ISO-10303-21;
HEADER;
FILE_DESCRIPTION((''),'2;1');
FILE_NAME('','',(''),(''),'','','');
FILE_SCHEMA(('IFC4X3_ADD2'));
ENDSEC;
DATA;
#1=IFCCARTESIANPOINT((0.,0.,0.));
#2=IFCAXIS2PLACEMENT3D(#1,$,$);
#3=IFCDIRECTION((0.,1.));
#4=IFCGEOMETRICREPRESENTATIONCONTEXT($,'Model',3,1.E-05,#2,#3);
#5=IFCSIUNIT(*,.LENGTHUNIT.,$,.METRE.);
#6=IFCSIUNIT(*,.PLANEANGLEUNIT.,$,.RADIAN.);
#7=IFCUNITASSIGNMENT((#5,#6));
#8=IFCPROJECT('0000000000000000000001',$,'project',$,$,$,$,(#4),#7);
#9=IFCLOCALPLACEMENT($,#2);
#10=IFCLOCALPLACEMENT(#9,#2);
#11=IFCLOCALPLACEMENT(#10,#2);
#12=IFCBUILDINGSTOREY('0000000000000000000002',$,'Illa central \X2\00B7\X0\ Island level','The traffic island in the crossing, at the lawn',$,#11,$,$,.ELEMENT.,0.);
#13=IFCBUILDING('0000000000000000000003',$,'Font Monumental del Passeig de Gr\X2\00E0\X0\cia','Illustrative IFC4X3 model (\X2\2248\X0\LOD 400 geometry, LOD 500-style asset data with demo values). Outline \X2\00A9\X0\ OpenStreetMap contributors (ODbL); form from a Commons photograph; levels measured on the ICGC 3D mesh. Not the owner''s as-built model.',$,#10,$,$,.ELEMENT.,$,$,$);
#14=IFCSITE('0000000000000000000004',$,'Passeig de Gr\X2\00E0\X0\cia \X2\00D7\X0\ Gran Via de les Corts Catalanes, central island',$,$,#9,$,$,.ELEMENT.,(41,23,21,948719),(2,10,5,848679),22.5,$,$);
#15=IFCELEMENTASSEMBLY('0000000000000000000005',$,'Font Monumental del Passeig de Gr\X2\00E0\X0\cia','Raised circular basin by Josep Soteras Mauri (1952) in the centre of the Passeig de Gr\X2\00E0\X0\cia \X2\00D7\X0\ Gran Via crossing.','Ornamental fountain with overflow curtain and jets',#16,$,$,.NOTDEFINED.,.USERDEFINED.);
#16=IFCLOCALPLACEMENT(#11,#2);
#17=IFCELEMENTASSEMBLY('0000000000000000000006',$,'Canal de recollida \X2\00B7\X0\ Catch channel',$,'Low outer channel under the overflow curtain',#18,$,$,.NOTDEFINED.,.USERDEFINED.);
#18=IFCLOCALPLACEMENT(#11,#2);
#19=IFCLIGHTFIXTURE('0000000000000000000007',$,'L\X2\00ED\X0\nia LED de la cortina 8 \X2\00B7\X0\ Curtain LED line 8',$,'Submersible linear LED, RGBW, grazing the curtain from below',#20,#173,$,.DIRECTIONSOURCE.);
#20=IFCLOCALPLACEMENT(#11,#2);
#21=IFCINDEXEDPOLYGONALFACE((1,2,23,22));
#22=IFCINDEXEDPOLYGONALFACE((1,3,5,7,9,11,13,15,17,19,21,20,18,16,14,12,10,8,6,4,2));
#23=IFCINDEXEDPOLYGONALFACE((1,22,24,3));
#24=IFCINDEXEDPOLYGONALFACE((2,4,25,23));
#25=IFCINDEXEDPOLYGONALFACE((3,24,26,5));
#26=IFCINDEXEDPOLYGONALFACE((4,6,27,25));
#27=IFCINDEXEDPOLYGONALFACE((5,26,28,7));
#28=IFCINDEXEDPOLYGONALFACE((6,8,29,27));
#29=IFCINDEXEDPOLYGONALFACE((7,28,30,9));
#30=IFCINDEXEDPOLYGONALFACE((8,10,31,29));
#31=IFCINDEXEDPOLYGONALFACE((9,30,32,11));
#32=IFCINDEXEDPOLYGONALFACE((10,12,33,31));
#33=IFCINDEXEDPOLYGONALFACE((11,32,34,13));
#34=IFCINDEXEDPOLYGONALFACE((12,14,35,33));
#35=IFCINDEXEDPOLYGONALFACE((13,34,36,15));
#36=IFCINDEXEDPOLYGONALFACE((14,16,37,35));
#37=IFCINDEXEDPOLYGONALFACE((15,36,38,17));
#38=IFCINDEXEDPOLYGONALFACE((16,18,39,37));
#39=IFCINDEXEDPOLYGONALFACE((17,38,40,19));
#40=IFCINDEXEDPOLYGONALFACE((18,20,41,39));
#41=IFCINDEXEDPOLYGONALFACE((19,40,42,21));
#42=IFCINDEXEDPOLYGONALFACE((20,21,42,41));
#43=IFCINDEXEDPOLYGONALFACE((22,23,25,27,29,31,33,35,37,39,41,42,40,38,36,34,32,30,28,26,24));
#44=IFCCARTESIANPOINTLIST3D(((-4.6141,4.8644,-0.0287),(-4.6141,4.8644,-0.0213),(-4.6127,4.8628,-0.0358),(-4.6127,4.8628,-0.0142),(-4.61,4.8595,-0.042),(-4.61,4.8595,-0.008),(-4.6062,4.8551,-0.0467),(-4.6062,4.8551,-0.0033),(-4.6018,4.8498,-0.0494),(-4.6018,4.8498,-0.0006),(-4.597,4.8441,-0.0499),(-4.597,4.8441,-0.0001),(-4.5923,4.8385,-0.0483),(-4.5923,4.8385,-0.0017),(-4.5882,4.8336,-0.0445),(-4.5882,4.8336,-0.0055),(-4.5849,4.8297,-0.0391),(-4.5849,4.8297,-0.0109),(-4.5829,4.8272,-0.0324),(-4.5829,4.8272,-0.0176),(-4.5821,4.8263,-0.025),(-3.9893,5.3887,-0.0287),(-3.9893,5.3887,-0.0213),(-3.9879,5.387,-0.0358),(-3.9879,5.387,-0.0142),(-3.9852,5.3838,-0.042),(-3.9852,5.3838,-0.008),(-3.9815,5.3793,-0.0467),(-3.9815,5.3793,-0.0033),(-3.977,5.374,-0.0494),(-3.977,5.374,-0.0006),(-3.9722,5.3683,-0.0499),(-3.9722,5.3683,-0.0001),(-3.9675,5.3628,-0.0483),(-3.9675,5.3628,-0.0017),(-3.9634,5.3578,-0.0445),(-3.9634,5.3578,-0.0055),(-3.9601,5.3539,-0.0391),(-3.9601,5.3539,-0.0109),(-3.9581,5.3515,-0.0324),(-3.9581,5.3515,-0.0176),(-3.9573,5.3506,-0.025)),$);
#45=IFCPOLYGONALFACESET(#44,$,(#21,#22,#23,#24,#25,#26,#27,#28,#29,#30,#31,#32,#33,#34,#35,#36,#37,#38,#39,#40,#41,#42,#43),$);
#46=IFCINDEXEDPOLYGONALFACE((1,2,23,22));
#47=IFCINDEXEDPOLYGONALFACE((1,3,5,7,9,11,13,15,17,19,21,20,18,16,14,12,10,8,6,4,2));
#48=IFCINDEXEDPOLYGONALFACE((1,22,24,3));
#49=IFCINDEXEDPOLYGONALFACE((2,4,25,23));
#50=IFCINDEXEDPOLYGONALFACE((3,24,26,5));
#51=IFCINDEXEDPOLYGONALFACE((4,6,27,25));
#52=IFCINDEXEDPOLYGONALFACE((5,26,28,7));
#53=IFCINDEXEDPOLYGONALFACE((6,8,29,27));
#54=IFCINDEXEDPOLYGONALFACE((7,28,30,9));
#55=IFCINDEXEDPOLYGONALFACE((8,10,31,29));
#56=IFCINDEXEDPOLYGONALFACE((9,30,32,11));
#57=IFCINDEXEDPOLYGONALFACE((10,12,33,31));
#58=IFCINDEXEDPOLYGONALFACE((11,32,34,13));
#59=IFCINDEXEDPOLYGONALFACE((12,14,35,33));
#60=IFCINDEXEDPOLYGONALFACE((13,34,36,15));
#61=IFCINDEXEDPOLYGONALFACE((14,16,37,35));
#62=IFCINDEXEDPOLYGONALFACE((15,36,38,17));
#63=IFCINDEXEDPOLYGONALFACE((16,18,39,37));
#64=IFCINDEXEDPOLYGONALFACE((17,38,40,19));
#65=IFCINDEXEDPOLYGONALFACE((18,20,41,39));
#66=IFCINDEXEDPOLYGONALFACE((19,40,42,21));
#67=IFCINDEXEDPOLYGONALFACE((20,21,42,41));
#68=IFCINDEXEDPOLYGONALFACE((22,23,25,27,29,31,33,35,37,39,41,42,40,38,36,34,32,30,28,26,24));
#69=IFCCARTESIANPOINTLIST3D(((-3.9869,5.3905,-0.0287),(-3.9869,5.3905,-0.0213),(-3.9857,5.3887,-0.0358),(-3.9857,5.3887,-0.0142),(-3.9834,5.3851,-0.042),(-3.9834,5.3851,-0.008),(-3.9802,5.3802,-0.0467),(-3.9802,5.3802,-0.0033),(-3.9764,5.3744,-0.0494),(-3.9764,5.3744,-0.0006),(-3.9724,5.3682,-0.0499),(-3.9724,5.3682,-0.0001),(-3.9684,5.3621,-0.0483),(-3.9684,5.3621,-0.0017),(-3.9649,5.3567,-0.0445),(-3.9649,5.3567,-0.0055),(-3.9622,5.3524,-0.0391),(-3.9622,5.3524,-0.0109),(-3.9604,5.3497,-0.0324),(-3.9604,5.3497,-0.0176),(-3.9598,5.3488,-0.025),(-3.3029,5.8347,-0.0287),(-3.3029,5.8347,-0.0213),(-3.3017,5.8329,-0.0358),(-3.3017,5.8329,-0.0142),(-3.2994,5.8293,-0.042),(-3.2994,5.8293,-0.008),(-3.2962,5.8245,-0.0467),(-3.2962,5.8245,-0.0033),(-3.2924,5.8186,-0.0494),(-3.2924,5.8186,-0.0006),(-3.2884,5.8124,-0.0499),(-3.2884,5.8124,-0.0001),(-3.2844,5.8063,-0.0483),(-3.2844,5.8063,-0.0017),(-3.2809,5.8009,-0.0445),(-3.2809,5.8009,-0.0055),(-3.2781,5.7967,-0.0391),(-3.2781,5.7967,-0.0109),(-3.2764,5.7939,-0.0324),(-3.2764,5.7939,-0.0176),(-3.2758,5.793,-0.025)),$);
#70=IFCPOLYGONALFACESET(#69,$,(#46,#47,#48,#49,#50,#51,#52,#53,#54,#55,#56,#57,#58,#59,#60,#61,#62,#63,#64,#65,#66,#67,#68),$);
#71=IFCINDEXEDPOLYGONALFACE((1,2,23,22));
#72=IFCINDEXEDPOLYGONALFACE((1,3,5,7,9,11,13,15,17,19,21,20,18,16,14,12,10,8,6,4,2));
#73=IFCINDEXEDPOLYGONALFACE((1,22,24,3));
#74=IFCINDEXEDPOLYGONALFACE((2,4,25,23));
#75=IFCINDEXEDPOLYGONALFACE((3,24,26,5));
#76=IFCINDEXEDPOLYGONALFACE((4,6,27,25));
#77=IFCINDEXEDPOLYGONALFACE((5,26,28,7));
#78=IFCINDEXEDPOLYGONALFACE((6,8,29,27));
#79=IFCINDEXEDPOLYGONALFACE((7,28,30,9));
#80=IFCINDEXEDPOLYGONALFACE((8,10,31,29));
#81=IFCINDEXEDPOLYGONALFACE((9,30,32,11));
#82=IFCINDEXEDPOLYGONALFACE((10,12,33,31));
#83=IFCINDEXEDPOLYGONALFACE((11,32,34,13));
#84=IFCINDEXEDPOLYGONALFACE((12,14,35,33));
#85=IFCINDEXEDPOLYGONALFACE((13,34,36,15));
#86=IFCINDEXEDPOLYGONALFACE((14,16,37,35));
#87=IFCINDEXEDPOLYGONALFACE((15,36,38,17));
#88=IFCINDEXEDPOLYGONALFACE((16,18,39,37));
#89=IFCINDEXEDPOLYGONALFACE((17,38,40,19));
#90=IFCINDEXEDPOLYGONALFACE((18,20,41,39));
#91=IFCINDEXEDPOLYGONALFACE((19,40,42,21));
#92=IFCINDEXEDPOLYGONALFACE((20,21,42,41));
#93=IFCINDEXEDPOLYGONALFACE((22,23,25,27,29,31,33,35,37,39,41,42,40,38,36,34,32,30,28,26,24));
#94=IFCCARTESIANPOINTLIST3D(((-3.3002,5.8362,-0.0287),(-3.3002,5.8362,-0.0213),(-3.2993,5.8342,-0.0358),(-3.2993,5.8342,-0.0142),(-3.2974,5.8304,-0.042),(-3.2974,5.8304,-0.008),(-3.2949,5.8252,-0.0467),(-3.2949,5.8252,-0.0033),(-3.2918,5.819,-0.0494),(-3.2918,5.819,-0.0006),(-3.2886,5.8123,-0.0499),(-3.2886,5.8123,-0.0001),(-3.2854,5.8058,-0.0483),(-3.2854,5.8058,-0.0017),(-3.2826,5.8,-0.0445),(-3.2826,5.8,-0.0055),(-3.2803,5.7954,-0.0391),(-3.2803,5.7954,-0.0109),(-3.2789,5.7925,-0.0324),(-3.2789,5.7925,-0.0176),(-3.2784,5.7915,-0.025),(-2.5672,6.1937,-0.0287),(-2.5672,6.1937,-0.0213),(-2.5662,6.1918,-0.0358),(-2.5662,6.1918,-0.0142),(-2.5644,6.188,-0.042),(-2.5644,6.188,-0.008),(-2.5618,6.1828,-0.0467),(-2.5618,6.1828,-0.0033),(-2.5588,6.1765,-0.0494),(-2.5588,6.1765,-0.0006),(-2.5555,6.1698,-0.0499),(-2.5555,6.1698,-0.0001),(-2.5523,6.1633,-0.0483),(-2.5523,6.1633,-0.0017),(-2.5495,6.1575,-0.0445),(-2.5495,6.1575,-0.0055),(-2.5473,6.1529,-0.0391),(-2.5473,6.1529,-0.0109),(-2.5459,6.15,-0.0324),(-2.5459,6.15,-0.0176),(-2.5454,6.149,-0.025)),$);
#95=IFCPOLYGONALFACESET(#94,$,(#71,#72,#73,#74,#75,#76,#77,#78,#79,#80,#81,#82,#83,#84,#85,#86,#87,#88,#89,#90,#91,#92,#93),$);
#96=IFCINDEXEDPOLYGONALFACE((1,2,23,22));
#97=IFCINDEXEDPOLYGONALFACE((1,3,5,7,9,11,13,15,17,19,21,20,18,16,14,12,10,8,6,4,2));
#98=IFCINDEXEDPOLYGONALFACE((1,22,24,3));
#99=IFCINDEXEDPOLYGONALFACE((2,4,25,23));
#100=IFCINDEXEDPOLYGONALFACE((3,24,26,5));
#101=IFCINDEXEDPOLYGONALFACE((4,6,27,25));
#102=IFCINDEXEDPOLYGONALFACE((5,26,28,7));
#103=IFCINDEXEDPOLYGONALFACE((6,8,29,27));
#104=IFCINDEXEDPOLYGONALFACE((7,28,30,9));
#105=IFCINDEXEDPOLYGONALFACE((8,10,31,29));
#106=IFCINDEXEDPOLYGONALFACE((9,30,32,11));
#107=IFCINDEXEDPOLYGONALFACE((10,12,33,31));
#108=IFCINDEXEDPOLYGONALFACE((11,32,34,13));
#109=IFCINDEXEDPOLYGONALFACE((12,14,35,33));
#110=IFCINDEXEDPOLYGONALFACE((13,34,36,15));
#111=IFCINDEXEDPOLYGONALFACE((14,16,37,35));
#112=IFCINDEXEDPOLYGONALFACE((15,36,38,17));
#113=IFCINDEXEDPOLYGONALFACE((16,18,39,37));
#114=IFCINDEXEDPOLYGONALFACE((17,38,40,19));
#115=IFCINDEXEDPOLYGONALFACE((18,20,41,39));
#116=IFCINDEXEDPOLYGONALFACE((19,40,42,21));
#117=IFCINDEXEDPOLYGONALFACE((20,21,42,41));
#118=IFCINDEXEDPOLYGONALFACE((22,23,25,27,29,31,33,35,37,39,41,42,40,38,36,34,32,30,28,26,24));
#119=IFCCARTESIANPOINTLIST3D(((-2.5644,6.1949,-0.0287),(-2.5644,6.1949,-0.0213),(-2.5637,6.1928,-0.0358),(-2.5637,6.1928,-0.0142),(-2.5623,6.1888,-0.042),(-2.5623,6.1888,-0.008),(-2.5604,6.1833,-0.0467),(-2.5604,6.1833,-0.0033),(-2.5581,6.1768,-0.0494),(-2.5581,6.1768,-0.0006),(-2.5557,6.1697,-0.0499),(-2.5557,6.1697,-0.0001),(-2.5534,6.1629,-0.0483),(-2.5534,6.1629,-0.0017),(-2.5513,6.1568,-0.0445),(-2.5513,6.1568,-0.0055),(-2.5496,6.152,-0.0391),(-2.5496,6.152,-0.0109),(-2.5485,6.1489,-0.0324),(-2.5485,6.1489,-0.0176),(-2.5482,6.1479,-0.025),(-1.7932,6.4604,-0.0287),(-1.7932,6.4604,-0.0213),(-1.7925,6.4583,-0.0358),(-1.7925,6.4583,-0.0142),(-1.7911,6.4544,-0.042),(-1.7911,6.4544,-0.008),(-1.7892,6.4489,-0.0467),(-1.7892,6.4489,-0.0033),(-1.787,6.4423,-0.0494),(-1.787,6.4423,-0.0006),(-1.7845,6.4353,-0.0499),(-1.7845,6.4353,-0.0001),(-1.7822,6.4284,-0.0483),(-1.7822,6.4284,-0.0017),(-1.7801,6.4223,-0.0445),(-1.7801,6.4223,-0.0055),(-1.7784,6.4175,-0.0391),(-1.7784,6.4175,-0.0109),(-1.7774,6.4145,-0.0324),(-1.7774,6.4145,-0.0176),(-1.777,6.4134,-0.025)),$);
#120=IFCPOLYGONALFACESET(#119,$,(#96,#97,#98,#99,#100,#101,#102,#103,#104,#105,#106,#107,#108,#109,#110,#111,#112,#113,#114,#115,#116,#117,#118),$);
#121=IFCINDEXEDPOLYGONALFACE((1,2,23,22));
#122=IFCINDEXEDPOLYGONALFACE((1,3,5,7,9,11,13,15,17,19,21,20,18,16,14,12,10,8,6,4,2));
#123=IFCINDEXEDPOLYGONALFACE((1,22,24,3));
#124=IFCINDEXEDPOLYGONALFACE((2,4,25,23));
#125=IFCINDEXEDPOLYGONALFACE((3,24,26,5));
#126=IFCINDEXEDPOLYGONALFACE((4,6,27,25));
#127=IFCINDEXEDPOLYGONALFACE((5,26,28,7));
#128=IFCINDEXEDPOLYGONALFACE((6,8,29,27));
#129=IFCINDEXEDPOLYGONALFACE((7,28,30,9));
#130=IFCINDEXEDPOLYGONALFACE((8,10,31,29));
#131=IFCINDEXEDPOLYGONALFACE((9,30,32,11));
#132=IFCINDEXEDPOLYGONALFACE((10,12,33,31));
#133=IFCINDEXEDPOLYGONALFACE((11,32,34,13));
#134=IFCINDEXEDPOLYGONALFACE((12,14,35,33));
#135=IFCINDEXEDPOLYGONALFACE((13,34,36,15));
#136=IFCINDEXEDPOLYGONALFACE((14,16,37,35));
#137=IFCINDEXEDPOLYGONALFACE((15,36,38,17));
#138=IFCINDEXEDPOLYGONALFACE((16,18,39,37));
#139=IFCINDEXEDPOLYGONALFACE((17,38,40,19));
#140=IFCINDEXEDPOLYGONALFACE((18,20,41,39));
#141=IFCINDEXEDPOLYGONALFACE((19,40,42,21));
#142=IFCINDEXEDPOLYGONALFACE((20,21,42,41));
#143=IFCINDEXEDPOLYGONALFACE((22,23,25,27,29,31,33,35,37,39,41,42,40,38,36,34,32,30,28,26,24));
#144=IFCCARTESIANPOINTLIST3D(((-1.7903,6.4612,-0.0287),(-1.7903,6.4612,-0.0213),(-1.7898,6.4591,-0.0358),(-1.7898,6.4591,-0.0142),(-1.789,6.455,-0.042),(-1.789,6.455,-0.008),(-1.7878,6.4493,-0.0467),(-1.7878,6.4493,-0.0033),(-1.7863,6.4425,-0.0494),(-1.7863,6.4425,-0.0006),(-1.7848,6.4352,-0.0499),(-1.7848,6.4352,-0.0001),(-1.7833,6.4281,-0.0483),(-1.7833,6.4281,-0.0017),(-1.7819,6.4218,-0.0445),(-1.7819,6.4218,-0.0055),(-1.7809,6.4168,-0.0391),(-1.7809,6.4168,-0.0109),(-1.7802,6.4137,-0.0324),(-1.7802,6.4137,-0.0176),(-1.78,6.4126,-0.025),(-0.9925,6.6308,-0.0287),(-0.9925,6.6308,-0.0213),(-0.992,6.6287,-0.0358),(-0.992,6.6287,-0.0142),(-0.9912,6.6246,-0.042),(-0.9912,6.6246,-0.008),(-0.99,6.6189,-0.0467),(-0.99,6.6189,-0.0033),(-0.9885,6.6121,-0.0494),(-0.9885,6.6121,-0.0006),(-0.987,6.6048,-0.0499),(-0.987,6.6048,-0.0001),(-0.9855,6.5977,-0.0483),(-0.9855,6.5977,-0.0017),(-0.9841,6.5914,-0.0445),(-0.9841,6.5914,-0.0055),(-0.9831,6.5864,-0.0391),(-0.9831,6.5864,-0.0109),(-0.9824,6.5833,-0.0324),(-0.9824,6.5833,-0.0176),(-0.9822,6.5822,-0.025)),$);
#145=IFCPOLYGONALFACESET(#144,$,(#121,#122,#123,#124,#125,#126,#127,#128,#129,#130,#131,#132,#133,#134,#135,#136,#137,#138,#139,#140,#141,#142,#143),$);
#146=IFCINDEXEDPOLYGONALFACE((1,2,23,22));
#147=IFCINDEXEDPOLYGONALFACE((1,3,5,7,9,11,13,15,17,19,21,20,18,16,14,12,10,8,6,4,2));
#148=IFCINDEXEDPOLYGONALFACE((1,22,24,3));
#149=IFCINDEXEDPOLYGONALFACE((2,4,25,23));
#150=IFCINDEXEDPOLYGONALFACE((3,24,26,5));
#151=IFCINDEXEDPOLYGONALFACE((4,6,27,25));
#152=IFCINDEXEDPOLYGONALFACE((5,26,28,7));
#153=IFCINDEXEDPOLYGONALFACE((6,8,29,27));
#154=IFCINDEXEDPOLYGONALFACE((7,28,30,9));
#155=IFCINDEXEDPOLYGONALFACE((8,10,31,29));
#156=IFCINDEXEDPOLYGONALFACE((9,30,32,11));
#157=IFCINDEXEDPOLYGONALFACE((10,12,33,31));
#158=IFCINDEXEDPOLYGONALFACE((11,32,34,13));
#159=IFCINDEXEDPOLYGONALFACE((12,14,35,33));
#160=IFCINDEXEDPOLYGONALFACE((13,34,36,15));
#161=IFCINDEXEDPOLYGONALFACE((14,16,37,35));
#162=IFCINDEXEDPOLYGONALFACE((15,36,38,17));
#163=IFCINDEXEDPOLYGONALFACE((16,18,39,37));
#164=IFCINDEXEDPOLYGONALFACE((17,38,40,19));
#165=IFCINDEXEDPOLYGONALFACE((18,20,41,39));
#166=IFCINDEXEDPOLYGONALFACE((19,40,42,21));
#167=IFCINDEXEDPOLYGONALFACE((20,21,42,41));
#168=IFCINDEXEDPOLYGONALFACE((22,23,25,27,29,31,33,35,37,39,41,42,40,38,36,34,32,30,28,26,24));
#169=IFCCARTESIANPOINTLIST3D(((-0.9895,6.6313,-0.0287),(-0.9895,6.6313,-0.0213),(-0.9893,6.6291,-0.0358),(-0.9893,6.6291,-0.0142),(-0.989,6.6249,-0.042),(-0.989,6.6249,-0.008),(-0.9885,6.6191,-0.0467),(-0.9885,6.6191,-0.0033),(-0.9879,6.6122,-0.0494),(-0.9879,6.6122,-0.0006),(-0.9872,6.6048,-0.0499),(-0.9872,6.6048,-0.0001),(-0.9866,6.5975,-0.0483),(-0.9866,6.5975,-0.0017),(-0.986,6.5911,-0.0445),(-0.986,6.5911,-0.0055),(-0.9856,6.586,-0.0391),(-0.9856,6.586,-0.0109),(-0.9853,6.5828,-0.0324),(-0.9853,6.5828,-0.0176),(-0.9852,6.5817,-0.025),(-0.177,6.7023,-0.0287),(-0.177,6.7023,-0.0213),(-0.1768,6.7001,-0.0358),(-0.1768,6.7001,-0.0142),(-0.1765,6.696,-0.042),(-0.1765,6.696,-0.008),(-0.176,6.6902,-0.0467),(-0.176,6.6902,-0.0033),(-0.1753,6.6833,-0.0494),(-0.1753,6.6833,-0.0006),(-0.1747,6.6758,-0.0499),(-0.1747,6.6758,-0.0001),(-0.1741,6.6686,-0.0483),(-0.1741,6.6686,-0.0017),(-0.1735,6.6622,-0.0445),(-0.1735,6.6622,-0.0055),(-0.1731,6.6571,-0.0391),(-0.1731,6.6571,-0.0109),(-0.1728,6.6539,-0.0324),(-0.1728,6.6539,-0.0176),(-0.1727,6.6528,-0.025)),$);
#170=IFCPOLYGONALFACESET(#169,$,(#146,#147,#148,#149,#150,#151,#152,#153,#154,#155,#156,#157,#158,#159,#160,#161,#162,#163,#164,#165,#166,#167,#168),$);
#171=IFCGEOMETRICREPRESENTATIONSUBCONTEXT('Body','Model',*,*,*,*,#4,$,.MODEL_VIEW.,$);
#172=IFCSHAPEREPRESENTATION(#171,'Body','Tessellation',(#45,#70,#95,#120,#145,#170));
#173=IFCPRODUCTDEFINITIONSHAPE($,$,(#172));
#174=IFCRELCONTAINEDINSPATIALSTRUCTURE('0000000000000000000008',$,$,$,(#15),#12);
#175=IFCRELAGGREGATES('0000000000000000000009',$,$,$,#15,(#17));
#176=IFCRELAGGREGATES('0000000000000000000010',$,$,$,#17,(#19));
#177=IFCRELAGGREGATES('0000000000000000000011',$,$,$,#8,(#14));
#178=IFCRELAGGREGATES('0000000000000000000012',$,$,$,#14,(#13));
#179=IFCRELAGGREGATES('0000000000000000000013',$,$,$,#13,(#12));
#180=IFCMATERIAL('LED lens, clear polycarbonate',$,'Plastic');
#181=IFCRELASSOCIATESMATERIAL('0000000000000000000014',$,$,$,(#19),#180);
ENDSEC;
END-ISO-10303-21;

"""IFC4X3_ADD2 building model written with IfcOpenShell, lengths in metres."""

from ifc_helpers import new_model, si_unit, direction, frame, origin, origin_2d_with_axis, place, context, subcontext, project, spatial, circle, extrude, material, element, aggregate, save


model = new_model("IFC4X3_ADD2")

# Units and contexts
model_context = context("Model", 3, precision=1e-05, world=origin(), true_north=direction((0.0, 1.0)))
body_context = subcontext(model_context, "Body", "Model", "MODEL_VIEW")
ifc_project = project(units=[si_unit("LENGTHUNIT", "METRE"), si_unit("PLANEANGLEUNIT", "RADIAN")], contexts=[model_context])

# Site, building, storey
site_placement = place(None, origin())
site = spatial("IfcSite", under=ifc_project, at=site_placement, Name="Passeig de Gràcia × Gran Via de les Corts Catalanes, central island", CompositionType="ELEMENT", RefLatitude=(41, 23, 21, 948719), RefLongitude=(2, 10, 5, 848679), RefElevation=22.5)
building_placement = place(site_placement, origin())
building = spatial("IfcBuilding", under=site, at=building_placement, Name="Font Monumental del Passeig de Gràcia", Description="Illustrative IFC4X3 model (≈LOD 400 geometry, LOD 500-style asset data with demo values). Outline © OpenStreetMap contributors (ODbL); form from a Commons photograph; levels measured on the ICGC 3D mesh. Not the owner's as-built model.", CompositionType="ELEMENT")
storey_placement = place(building_placement, origin())
storey = spatial("IfcBuildingStorey", under=building, at=storey_placement, Name="Illa central · Island level", Description="The traffic island in the crossing, at the lawn", CompositionType="ELEMENT", Elevation=0.0)

# Element assemblies, light fixture
assembly_1_placement = place(building_placement, origin())
assembly_1 = element("IfcElementAssembly", 1, at=assembly_1_placement, inside=storey, Name="Font Monumental del Passeig de Gràcia", Description="Raised circular basin by Josep Soteras Mauri (1952) in the centre of the Passeig de Gràcia × Gran Via crossing.", ObjectType="Ornamental fountain with overflow curtain and jets", AssemblyPlace="NOTDEFINED", PredefinedType="USERDEFINED")
assembly_2_placement = place(building_placement, origin())
assembly_2 = element("IfcElementAssembly", 2, at=assembly_2_placement, Name="Canal de recollida · Catch channel", ObjectType="Low outer channel under the overflow curtain", AssemblyPlace="NOTDEFINED", PredefinedType="USERDEFINED")
ifc_material_1 = material(Name="LED lens, clear polycarbonate", Category="Plastic")
light_fixture_1_placement = place(building_placement, origin())
light_fixture_1 = element("IfcLightFixture", 3, at=light_fixture_1_placement, material=ifc_material_1, Name="Línia LED de la cortina 8 · Curtain LED line 8", ObjectType="Submersible linear LED, RGBW, grazing the curtain from below", PredefinedType="DIRECTIONSOURCE", context=body_context, shape_type="SweptSolid", body=[
    extrude(circle(Radius=0.025, at=origin_2d_with_axis()), frame((-4.5982, 4.8455, -0.025), z_axis=(0.766044, 0.642788, 0.0), x_axis=(0.642788, -0.766044, 0.0)), (0.0, 0.0, 1.0), 0.8156),
    extrude(circle(Radius=0.025, at=origin_2d_with_axis()), frame((-3.9734, 5.3698, -0.025), z_axis=(0.838671, 0.544639, 0.0), x_axis=(0.544639, -0.838671, 0.0)), (0.0, 0.0, 1.0), 0.8156),
    extrude(circle(Radius=0.025, at=origin_2d_with_axis()), frame((-3.2894, 5.814, -0.025), z_axis=(0.898794, 0.438371, 0.0), x_axis=(0.438371, -0.898794, 0.0)), (0.0, 0.0, 1.0), 0.8156),
    extrude(circle(Radius=0.025, at=origin_2d_with_axis()), frame((-2.5563, 6.1715, -0.025), z_axis=(0.945519, 0.325568, 0.0), x_axis=(0.325568, -0.945519, 0.0)), (0.0, 0.0, 1.0), 0.8156),
    extrude(circle(Radius=0.025, at=origin_2d_with_axis()), frame((-1.7852, 6.4371, -0.025), z_axis=(0.978148, 0.207912, 0.0), x_axis=(0.207912, -0.978148, 0.0)), (0.0, 0.0, 1.0), 0.8156),
    extrude(circle(Radius=0.025, at=origin_2d_with_axis()), frame((-0.9874, 6.6066, -0.025), z_axis=(0.996195, 0.087156, 0.0), x_axis=(0.087156, -0.996195, 0.0)), (0.0, 0.0, 1.0), 0.8156),
])
aggregate(assembly_1, [assembly_2])
aggregate(assembly_2, [light_fixture_1])

save(model, "model.ifc")
